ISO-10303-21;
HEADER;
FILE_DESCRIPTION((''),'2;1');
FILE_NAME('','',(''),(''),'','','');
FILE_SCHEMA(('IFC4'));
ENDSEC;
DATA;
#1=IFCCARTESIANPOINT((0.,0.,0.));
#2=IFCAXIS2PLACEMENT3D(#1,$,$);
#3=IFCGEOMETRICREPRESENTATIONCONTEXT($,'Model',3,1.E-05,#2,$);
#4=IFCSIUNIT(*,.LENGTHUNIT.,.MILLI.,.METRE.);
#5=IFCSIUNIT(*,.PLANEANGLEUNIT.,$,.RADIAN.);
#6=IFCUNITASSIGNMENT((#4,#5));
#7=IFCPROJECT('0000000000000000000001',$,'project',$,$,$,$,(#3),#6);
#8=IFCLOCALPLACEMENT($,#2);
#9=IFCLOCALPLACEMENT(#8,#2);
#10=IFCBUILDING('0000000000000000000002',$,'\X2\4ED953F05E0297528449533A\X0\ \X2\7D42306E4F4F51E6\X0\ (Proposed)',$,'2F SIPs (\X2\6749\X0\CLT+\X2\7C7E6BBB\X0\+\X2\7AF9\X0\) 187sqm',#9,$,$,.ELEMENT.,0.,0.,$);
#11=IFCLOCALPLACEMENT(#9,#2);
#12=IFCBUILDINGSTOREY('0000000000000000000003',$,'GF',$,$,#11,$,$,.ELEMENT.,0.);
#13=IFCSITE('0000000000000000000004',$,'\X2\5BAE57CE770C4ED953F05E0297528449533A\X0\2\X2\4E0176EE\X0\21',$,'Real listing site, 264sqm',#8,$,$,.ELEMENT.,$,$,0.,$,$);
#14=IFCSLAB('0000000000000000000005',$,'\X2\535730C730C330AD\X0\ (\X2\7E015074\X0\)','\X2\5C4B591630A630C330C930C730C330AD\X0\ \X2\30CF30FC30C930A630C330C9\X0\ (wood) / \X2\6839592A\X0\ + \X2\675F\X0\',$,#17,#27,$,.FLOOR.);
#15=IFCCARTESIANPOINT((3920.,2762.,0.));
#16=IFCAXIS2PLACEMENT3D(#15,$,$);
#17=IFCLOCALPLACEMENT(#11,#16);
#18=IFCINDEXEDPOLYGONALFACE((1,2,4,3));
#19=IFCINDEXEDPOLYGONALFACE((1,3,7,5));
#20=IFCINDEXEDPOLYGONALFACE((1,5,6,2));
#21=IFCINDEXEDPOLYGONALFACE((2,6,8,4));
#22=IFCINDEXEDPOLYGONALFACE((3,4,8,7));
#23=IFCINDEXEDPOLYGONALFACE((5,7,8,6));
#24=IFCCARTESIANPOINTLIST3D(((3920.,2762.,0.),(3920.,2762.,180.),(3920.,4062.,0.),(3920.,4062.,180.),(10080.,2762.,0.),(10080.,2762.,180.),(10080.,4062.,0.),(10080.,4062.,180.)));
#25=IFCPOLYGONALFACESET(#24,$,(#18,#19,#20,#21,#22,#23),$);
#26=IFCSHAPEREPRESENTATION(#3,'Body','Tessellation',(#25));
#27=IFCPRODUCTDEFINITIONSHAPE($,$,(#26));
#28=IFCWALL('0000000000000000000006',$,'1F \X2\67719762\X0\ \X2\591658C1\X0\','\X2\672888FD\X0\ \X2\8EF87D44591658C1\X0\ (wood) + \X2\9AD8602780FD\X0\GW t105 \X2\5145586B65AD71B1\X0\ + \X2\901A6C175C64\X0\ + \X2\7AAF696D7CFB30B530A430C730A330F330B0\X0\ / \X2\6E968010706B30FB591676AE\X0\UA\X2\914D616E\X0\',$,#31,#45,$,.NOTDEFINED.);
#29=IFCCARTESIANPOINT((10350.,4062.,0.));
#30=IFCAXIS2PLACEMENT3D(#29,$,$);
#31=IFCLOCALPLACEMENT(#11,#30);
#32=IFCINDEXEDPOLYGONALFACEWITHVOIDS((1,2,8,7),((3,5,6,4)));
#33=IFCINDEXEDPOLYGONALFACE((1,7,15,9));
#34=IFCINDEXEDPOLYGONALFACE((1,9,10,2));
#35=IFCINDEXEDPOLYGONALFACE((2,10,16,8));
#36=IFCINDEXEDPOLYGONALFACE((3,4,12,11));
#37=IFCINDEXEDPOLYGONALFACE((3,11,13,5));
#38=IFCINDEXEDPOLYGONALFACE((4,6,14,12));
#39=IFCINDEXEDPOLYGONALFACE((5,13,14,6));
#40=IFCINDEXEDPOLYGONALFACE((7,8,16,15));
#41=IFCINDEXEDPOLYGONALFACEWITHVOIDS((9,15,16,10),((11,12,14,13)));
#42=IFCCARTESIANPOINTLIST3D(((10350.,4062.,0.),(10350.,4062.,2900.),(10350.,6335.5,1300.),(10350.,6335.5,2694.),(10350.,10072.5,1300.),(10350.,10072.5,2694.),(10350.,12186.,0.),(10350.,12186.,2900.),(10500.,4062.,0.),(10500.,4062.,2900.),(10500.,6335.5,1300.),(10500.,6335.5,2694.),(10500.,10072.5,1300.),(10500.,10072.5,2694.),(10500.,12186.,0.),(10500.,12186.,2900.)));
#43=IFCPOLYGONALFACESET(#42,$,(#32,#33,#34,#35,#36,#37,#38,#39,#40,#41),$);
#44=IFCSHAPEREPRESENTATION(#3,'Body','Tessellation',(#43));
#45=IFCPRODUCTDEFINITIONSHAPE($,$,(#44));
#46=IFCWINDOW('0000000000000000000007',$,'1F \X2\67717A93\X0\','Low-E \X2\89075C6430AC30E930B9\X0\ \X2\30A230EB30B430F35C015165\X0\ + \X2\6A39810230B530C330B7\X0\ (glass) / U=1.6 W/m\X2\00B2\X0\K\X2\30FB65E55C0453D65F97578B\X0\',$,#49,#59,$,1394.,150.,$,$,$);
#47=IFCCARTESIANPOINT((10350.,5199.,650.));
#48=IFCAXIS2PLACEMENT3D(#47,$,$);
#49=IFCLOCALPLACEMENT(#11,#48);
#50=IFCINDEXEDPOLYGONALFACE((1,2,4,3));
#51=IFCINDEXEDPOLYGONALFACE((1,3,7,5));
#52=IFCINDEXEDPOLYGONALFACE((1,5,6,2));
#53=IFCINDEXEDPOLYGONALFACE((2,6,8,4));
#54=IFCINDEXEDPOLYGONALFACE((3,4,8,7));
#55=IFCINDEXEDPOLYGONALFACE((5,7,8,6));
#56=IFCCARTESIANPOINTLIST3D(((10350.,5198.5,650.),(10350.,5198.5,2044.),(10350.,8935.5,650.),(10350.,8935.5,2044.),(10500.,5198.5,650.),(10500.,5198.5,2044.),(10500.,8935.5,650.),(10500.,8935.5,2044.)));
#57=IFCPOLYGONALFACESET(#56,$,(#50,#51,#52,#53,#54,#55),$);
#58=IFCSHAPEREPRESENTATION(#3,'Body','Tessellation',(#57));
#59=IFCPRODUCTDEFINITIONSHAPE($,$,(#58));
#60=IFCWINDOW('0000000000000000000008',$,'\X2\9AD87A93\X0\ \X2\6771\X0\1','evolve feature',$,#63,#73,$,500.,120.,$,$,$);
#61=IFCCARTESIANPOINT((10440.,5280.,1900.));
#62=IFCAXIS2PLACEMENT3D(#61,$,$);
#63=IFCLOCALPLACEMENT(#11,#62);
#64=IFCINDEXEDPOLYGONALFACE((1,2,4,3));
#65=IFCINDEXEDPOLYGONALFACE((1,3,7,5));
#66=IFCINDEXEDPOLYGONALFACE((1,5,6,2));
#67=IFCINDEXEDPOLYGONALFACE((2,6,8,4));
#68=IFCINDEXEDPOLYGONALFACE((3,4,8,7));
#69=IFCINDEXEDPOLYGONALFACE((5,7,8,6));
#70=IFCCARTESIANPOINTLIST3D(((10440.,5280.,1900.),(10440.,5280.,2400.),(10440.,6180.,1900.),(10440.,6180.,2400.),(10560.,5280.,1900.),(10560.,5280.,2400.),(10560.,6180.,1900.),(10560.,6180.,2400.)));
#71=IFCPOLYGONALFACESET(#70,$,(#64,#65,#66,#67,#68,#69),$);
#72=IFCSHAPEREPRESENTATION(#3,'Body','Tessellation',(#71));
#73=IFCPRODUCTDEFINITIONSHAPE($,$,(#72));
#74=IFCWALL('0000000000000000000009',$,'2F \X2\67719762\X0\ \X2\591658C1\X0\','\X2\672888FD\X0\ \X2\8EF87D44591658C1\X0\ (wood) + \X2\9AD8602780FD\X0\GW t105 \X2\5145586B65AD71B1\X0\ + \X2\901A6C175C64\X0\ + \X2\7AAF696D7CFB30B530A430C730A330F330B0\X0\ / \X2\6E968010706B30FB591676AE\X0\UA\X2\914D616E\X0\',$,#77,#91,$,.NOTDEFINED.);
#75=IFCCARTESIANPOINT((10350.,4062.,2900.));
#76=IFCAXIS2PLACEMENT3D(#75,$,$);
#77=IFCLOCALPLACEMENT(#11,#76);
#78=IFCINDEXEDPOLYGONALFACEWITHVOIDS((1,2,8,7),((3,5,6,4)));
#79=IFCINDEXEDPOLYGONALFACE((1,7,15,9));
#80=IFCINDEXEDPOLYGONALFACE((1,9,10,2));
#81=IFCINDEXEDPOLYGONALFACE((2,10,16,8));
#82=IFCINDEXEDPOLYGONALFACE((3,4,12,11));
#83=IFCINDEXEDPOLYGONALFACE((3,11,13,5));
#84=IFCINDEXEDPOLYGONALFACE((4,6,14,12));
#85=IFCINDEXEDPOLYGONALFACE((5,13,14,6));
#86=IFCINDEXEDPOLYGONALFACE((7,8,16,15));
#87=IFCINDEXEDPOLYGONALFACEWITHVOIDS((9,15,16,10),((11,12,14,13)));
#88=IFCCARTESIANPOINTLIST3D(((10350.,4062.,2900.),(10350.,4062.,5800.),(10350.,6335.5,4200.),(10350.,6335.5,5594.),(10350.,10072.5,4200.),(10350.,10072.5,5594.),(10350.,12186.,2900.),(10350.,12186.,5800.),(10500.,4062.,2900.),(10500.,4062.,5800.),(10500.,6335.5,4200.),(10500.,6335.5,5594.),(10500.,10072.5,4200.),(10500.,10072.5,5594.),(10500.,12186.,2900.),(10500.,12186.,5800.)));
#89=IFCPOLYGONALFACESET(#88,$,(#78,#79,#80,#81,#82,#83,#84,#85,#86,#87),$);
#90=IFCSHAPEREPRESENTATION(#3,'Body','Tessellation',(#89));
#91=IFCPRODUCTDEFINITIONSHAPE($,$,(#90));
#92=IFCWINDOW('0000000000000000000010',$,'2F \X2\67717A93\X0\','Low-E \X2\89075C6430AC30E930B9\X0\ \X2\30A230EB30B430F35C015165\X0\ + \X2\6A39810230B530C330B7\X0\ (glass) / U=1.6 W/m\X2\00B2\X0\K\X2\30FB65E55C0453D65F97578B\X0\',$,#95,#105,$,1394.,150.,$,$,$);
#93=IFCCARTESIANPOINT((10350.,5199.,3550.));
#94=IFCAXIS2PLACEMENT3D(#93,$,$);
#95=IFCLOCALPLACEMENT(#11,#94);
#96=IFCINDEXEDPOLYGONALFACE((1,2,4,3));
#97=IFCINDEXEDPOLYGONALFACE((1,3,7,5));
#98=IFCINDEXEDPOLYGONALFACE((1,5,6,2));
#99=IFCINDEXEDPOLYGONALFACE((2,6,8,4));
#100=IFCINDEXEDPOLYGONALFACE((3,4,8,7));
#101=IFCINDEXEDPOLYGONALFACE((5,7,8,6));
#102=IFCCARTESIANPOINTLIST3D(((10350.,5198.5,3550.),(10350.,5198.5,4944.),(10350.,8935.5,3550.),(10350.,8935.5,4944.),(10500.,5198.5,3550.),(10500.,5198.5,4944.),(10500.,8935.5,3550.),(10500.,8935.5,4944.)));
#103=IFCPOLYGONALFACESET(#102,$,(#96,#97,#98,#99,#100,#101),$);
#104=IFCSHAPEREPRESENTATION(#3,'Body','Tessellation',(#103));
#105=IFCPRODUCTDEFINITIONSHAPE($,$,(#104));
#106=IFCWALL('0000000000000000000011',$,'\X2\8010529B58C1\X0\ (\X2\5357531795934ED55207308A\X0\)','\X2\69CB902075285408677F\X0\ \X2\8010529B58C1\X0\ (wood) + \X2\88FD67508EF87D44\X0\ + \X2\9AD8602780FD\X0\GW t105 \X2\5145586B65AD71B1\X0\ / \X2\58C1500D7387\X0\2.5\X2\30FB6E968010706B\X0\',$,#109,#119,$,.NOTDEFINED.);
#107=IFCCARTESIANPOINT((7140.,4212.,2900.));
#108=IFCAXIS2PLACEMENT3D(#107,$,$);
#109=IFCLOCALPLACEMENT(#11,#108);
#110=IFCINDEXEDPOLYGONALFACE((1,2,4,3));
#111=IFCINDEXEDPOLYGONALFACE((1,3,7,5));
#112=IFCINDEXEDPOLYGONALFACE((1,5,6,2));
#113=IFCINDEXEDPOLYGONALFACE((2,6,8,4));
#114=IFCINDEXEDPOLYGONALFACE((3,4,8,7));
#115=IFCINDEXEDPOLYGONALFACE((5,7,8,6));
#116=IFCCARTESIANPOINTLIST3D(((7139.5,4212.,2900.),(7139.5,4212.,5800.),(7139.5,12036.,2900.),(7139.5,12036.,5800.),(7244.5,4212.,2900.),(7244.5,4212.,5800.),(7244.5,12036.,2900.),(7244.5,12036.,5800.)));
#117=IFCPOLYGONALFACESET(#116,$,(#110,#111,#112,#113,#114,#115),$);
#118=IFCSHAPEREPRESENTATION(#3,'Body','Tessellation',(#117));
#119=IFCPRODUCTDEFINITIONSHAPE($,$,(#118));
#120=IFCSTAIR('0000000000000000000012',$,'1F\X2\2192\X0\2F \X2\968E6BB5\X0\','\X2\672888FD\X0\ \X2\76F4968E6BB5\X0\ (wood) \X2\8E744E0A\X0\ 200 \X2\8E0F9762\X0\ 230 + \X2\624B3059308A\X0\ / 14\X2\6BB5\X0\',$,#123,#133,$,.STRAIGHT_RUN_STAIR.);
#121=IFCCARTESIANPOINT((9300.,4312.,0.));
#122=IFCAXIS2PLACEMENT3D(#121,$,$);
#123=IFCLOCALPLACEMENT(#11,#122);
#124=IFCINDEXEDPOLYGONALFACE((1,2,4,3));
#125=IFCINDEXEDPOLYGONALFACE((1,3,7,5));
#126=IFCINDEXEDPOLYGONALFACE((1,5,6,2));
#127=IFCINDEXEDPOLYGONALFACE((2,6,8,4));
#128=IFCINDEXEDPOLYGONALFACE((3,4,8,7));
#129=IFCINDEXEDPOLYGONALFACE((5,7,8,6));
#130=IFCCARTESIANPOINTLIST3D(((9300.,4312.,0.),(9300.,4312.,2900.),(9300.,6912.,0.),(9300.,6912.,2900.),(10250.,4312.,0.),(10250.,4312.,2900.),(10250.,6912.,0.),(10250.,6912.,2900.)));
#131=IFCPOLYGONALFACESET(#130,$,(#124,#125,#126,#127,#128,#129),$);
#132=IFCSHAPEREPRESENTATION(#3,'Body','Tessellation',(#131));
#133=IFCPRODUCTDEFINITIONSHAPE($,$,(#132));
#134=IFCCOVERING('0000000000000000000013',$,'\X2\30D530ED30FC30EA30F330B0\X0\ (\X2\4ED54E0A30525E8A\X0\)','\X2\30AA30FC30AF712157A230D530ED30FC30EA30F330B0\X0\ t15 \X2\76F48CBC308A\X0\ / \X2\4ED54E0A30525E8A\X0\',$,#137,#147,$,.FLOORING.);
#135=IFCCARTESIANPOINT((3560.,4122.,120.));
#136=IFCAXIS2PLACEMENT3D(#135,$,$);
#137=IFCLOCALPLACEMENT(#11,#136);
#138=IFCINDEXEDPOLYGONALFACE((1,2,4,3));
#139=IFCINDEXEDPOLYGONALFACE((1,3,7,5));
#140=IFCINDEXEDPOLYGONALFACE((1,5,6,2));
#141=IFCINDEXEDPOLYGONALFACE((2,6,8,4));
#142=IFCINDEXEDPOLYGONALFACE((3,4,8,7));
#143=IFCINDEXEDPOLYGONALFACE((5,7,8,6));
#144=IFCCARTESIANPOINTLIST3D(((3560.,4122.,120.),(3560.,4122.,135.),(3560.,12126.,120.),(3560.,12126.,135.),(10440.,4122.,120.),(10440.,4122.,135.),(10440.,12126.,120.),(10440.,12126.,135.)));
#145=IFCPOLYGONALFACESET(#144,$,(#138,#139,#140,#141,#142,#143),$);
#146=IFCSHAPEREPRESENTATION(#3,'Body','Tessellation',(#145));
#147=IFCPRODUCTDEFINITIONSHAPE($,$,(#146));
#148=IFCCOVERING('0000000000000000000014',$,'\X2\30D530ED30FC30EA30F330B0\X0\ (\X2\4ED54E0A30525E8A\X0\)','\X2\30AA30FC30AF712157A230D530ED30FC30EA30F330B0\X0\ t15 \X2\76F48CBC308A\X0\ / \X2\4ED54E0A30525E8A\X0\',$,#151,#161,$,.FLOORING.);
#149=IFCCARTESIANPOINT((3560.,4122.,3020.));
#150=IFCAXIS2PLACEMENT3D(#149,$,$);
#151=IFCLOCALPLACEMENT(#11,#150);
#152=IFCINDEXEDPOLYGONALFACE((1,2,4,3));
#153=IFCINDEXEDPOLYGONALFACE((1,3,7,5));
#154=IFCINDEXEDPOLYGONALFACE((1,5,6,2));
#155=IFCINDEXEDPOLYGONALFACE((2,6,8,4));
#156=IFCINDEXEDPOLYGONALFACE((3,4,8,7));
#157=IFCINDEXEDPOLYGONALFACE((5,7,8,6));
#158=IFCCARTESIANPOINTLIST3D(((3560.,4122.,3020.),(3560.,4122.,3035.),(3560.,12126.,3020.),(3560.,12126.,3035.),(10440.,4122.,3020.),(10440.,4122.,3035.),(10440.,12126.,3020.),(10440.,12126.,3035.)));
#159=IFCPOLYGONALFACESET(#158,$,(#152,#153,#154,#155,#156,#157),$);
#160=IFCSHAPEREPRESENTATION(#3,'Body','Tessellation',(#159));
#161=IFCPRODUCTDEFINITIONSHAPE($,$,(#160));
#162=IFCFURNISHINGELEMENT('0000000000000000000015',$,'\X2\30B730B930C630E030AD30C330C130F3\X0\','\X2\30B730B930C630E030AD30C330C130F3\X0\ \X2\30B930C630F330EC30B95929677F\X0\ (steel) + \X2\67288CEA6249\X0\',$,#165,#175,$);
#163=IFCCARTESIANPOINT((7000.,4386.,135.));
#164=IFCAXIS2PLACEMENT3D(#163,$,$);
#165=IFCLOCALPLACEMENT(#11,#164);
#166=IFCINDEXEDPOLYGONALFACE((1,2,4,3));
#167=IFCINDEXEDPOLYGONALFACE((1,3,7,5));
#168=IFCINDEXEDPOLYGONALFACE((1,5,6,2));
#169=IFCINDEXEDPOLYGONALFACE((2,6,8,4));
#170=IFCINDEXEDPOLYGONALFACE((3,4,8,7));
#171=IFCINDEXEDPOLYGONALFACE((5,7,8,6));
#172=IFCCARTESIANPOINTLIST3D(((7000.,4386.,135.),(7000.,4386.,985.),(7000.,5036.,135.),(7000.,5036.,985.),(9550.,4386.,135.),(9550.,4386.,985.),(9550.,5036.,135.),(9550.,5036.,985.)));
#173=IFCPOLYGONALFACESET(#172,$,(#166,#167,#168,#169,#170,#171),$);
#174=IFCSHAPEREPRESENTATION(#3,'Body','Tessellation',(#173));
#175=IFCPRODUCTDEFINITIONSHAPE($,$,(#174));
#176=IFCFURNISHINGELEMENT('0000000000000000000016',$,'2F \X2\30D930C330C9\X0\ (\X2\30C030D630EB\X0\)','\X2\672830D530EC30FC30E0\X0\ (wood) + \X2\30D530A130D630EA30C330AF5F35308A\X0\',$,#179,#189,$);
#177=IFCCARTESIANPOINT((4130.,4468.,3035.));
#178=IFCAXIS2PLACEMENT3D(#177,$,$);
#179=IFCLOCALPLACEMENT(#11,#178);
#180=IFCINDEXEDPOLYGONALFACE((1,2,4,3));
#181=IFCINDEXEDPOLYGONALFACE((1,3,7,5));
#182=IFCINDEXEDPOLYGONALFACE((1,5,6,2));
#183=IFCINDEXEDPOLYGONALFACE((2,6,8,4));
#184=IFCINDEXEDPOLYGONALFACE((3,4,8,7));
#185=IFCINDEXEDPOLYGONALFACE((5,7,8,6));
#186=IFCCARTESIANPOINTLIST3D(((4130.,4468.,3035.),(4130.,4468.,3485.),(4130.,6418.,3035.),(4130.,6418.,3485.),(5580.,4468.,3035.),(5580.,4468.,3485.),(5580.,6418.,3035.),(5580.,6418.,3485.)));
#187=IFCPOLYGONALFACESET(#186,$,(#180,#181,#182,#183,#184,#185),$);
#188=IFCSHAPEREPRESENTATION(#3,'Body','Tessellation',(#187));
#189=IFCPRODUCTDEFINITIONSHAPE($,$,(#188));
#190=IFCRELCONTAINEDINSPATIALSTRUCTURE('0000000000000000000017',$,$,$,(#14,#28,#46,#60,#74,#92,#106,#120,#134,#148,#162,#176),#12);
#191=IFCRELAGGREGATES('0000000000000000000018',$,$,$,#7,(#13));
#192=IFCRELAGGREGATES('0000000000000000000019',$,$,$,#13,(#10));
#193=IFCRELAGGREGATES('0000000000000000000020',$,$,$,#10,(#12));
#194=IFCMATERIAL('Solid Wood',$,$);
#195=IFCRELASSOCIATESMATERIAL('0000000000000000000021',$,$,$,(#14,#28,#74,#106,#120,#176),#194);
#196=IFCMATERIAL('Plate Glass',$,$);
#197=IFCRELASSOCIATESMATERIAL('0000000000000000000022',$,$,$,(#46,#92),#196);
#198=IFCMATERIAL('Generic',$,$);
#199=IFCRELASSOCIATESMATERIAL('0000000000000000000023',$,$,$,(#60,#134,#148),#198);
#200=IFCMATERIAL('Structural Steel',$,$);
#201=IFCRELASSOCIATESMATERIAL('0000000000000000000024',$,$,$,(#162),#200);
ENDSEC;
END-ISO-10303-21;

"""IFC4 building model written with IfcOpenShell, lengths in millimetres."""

from ifc_helpers import new_model, si_unit, frame, frame_2d, origin, place, context, project, spatial, rectangle, extrude, material, element, fill, save


model = new_model("IFC4")

# Units and contexts
model_context = context("Model", 3, precision=1e-05, world=origin())
ifc_project = project(units=[si_unit("LENGTHUNIT", "METRE", prefix="MILLI"), si_unit("PLANEANGLEUNIT", "RADIAN")], contexts=[model_context])

# Site, building, storey
site_placement = place(None, origin())
site = spatial("IfcSite", under=ifc_project, at=site_placement, Name="宮城県仙台市青葉区2丁目21", ObjectType="Real listing site, 264sqm", CompositionType="ELEMENT", RefElevation=0.0)
building_placement = place(site_placement, origin())
building = spatial("IfcBuilding", under=site, at=building_placement, Name="仙台市青葉区 終の住処 (Proposed)", ObjectType="2F SIPs (杉CLT+籾殻+竹) 187sqm", CompositionType="ELEMENT", ElevationOfRefHeight=0.0, ElevationOfTerrain=0.0)
storey_placement = place(building_placement, origin())
storey = spatial("IfcBuildingStorey", under=building, at=storey_placement, Name="GF", CompositionType="ELEMENT", Elevation=0.0)

# Slab
ifc_material_1 = material(Name="Solid Wood")
slab_placement = place(storey_placement, frame((3920.0, 2762.0, 0.0)))
element("IfcSlab", 1, at=slab_placement, inside=storey, material=ifc_material_1, Name="南デッキ (縁側)", Description="屋外ウッドデッキ ハードウッド (wood) / 根太 + 束", PredefinedType="FLOOR", context=model_context, shape_type="SweptSolid", body=[
    extrude(rectangle(XDim=6160.0, YDim=1300.0, at=frame_2d((3080.0, 650.0))), frame((3920.0, 2762.0, 0.0)), (0.0, 0.0, 1.0), 180.0),
])

# Wall, openings, windows
wall_1_placement = place(storey_placement, frame((10350.0, 4062.0, 0.0)))
wall_1 = element("IfcWall", 2, at=wall_1_placement, inside=storey, material=ifc_material_1, Name="1F 東面 外壁", Description="木製 軸組外壁 (wood) + 高性能GW t105 充填断熱 + 通気層 + 窯業系サイディング / 準耐火・外皮UA配慮", PredefinedType="NOTDEFINED", context=model_context, shape_type="SweptSolid", body=[
    extrude(rectangle(XDim=150.0, YDim=8124.0, at=frame_2d((75.0, 4062.0))), frame((10350.0, 4062.0, 0.0)), (0.0, 0.0, 1.0), 2900.0),
])
opening_1_placement = place(storey_placement, frame((10350.0, 5199.0, 650.0)))
opening_1 = element("IfcOpeningElement", 3, at=opening_1_placement, cuts=wall_1, PredefinedType="NOTDEFINED", context=model_context, shape_type="SweptSolid", body=[
    extrude(rectangle(XDim=150.0, YDim=3737.0, at=frame_2d((75.0, 1868.0))), frame((10350.0, 5199.0, 650.0)), (0.0, 0.0, 1.0), 1394.0),
])
opening_2_placement = place(storey_placement, frame((10440.0, 5280.0, 1900.0)))
opening_2 = element("IfcOpeningElement", 4, at=opening_2_placement, cuts=wall_1, PredefinedType="NOTDEFINED", context=model_context, shape_type="SweptSolid", body=[
    extrude(rectangle(XDim=120.0, YDim=900.0, at=frame_2d((60.0, 450.0))), frame((10440.0, 5280.0, 1900.0)), (0.0, 0.0, 1.0), 500.0),
])
ifc_material_2 = material(Name="Plate Glass")
window_1_placement = place(storey_placement, frame((10350.0, 5199.0, 650.0)))
window_1 = element("IfcWindow", 5, at=window_1_placement, inside=storey, material=ifc_material_2, Name="1F 東窓", Description="Low-E 複層ガラス アルゴン封入 + 樹脂サッシ (glass) / U=1.6 W/m²K・日射取得型", OverallHeight=1394.0, OverallWidth=150.0, context=model_context, shape_type="SweptSolid", body=[
    extrude(rectangle(XDim=150.0, YDim=3737.0, at=frame_2d((75.0, 1868.0))), frame((10350.0, 5199.0, 650.0)), (0.0, 0.0, 1.0), 1394.0),
])
fill(opening_1, window_1)
ifc_material_3 = material(Name="Generic")
window_2_placement = place(storey_placement, frame((10440.0, 5280.0, 1900.0)))
window_2 = element("IfcWindow", 6, at=window_2_placement, inside=storey, material=ifc_material_3, Name="高窓 東1", Description="evolve feature", OverallHeight=500.0, OverallWidth=120.0, context=model_context, shape_type="SweptSolid", body=[
    extrude(rectangle(XDim=120.0, YDim=900.0, at=frame_2d((60.0, 450.0))), frame((10440.0, 5280.0, 1900.0)), (0.0, 0.0, 1.0), 500.0),
])
fill(opening_2, window_2)

# Wall, opening, window
wall_2_placement = place(storey_placement, frame((10350.0, 4062.0, 2900.0)))
wall_2 = element("IfcWall", 7, at=wall_2_placement, inside=storey, material=ifc_material_1, Name="2F 東面 外壁", Description="木製 軸組外壁 (wood) + 高性能GW t105 充填断熱 + 通気層 + 窯業系サイディング / 準耐火・外皮UA配慮", PredefinedType="NOTDEFINED", context=model_context, shape_type="SweptSolid", body=[
    extrude(rectangle(XDim=150.0, YDim=8124.0, at=frame_2d((75.0, 4062.0))), frame((10350.0, 4062.0, 2900.0)), (0.0, 0.0, 1.0), 2900.0),
])
opening_3_placement = place(storey_placement, frame((10350.0, 5199.0, 3550.0)))
opening_3 = element("IfcOpeningElement", 8, at=opening_3_placement, cuts=wall_2, PredefinedType="NOTDEFINED", context=model_context, shape_type="SweptSolid", body=[
    extrude(rectangle(XDim=150.0, YDim=3737.0, at=frame_2d((75.0, 1868.0))), frame((10350.0, 5199.0, 3550.0)), (0.0, 0.0, 1.0), 1394.0),
])
window_3_placement = place(storey_placement, frame((10350.0, 5199.0, 3550.0)))
window_3 = element("IfcWindow", 9, at=window_3_placement, inside=storey, material=ifc_material_2, Name="2F 東窓", Description="Low-E 複層ガラス アルゴン封入 + 樹脂サッシ (glass) / U=1.6 W/m²K・日射取得型", OverallHeight=1394.0, OverallWidth=150.0, context=model_context, shape_type="SweptSolid", body=[
    extrude(rectangle(XDim=150.0, YDim=3737.0, at=frame_2d((75.0, 1868.0))), frame((10350.0, 5199.0, 3550.0)), (0.0, 0.0, 1.0), 1394.0),
])
fill(opening_3, window_3)

# Wall
wall_3_placement = place(storey_placement, frame((7140.0, 4212.0, 2900.0)))
element("IfcWall", 10, at=wall_3_placement, inside=storey, material=ifc_material_1, Name="耐力壁 (南北間仕切り)", Description="構造用合板 耐力壁 (wood) + 製材軸組 + 高性能GW t105 充填断熱 / 壁倍率2.5・準耐火", PredefinedType="NOTDEFINED", context=model_context, shape_type="SweptSolid", body=[
    extrude(rectangle(XDim=105.0, YDim=7824.0, at=frame_2d((52.0, 3912.0))), frame((7140.0, 4212.0, 2900.0)), (0.0, 0.0, 1.0), 2900.0),
])

# Stair
stair_placement = place(storey_placement, frame((9300.0, 4312.0, 0.0)))
element("IfcStair", 11, at=stair_placement, inside=storey, material=ifc_material_1, Name="1F→2F 階段", Description="木製 直階段 (wood) 蹴上 200 踏面 230 + 手すり / 14段", PredefinedType="STRAIGHT_RUN_STAIR", context=model_context, shape_type="SweptSolid", body=[
    extrude(rectangle(XDim=950.0, YDim=2600.0, at=frame_2d((475.0, 1300.0))), frame((9300.0, 4312.0, 0.0)), (0.0, 0.0, 1.0), 2900.0),
])

# Coverings
covering_1_placement = place(storey_placement, frame((3560.0, 4122.0, 120.0)))
element("IfcCovering", 12, at=covering_1_placement, inside=storey, material=ifc_material_3, Name="フローリング (仕上げ床)", Description="オーク無垢フローリング t15 直貼り / 仕上げ床", PredefinedType="FLOORING", context=model_context, shape_type="SweptSolid", body=[
    extrude(rectangle(XDim=6880.0, YDim=8004.0, at=frame_2d((3440.0, 4002.0))), frame((3560.0, 4122.0, 120.0)), (0.0, 0.0, 1.0), 15.0),
])
covering_2_placement = place(storey_placement, frame((3560.0, 4122.0, 3020.0)))
element("IfcCovering", 13, at=covering_2_placement, inside=storey, material=ifc_material_3, Name="フローリング (仕上げ床)", Description="オーク無垢フローリング t15 直貼り / 仕上げ床", PredefinedType="FLOORING", context=model_context, shape_type="SweptSolid", body=[
    extrude(rectangle(XDim=6880.0, YDim=8004.0, at=frame_2d((3440.0, 4002.0))), frame((3560.0, 4122.0, 3020.0)), (0.0, 0.0, 1.0), 15.0),
])

# Furnishing elements
ifc_material_4 = material(Name="Structural Steel")
furnishing_1_placement = place(storey_placement, frame((7000.0, 4386.0, 135.0)))
element("IfcFurnishingElement", 14, at=furnishing_1_placement, inside=storey, material=ifc_material_4, Name="システムキッチン", Description="システムキッチン ステンレス天板 (steel) + 木質扉", context=model_context, shape_type="SweptSolid", body=[
    extrude(rectangle(XDim=2550.0, YDim=650.0, at=frame_2d((1275.0, 325.0))), frame((7000.0, 4386.0, 135.0)), (0.0, 0.0, 1.0), 850.0),
])
furnishing_2_placement = place(storey_placement, frame((4130.0, 4468.0, 3035.0)))
element("IfcFurnishingElement", 15, at=furnishing_2_placement, inside=storey, material=ifc_material_1, Name="2F ベッド (ダブル)", Description="木フレーム (wood) + ファブリック張り", context=model_context, shape_type="SweptSolid", body=[
    extrude(rectangle(XDim=1450.0, YDim=1950.0, at=frame_2d((725.0, 975.0))), frame((4130.0, 4468.0, 3035.0)), (0.0, 0.0, 1.0), 450.0),
])

save(model, "model.ifc")
